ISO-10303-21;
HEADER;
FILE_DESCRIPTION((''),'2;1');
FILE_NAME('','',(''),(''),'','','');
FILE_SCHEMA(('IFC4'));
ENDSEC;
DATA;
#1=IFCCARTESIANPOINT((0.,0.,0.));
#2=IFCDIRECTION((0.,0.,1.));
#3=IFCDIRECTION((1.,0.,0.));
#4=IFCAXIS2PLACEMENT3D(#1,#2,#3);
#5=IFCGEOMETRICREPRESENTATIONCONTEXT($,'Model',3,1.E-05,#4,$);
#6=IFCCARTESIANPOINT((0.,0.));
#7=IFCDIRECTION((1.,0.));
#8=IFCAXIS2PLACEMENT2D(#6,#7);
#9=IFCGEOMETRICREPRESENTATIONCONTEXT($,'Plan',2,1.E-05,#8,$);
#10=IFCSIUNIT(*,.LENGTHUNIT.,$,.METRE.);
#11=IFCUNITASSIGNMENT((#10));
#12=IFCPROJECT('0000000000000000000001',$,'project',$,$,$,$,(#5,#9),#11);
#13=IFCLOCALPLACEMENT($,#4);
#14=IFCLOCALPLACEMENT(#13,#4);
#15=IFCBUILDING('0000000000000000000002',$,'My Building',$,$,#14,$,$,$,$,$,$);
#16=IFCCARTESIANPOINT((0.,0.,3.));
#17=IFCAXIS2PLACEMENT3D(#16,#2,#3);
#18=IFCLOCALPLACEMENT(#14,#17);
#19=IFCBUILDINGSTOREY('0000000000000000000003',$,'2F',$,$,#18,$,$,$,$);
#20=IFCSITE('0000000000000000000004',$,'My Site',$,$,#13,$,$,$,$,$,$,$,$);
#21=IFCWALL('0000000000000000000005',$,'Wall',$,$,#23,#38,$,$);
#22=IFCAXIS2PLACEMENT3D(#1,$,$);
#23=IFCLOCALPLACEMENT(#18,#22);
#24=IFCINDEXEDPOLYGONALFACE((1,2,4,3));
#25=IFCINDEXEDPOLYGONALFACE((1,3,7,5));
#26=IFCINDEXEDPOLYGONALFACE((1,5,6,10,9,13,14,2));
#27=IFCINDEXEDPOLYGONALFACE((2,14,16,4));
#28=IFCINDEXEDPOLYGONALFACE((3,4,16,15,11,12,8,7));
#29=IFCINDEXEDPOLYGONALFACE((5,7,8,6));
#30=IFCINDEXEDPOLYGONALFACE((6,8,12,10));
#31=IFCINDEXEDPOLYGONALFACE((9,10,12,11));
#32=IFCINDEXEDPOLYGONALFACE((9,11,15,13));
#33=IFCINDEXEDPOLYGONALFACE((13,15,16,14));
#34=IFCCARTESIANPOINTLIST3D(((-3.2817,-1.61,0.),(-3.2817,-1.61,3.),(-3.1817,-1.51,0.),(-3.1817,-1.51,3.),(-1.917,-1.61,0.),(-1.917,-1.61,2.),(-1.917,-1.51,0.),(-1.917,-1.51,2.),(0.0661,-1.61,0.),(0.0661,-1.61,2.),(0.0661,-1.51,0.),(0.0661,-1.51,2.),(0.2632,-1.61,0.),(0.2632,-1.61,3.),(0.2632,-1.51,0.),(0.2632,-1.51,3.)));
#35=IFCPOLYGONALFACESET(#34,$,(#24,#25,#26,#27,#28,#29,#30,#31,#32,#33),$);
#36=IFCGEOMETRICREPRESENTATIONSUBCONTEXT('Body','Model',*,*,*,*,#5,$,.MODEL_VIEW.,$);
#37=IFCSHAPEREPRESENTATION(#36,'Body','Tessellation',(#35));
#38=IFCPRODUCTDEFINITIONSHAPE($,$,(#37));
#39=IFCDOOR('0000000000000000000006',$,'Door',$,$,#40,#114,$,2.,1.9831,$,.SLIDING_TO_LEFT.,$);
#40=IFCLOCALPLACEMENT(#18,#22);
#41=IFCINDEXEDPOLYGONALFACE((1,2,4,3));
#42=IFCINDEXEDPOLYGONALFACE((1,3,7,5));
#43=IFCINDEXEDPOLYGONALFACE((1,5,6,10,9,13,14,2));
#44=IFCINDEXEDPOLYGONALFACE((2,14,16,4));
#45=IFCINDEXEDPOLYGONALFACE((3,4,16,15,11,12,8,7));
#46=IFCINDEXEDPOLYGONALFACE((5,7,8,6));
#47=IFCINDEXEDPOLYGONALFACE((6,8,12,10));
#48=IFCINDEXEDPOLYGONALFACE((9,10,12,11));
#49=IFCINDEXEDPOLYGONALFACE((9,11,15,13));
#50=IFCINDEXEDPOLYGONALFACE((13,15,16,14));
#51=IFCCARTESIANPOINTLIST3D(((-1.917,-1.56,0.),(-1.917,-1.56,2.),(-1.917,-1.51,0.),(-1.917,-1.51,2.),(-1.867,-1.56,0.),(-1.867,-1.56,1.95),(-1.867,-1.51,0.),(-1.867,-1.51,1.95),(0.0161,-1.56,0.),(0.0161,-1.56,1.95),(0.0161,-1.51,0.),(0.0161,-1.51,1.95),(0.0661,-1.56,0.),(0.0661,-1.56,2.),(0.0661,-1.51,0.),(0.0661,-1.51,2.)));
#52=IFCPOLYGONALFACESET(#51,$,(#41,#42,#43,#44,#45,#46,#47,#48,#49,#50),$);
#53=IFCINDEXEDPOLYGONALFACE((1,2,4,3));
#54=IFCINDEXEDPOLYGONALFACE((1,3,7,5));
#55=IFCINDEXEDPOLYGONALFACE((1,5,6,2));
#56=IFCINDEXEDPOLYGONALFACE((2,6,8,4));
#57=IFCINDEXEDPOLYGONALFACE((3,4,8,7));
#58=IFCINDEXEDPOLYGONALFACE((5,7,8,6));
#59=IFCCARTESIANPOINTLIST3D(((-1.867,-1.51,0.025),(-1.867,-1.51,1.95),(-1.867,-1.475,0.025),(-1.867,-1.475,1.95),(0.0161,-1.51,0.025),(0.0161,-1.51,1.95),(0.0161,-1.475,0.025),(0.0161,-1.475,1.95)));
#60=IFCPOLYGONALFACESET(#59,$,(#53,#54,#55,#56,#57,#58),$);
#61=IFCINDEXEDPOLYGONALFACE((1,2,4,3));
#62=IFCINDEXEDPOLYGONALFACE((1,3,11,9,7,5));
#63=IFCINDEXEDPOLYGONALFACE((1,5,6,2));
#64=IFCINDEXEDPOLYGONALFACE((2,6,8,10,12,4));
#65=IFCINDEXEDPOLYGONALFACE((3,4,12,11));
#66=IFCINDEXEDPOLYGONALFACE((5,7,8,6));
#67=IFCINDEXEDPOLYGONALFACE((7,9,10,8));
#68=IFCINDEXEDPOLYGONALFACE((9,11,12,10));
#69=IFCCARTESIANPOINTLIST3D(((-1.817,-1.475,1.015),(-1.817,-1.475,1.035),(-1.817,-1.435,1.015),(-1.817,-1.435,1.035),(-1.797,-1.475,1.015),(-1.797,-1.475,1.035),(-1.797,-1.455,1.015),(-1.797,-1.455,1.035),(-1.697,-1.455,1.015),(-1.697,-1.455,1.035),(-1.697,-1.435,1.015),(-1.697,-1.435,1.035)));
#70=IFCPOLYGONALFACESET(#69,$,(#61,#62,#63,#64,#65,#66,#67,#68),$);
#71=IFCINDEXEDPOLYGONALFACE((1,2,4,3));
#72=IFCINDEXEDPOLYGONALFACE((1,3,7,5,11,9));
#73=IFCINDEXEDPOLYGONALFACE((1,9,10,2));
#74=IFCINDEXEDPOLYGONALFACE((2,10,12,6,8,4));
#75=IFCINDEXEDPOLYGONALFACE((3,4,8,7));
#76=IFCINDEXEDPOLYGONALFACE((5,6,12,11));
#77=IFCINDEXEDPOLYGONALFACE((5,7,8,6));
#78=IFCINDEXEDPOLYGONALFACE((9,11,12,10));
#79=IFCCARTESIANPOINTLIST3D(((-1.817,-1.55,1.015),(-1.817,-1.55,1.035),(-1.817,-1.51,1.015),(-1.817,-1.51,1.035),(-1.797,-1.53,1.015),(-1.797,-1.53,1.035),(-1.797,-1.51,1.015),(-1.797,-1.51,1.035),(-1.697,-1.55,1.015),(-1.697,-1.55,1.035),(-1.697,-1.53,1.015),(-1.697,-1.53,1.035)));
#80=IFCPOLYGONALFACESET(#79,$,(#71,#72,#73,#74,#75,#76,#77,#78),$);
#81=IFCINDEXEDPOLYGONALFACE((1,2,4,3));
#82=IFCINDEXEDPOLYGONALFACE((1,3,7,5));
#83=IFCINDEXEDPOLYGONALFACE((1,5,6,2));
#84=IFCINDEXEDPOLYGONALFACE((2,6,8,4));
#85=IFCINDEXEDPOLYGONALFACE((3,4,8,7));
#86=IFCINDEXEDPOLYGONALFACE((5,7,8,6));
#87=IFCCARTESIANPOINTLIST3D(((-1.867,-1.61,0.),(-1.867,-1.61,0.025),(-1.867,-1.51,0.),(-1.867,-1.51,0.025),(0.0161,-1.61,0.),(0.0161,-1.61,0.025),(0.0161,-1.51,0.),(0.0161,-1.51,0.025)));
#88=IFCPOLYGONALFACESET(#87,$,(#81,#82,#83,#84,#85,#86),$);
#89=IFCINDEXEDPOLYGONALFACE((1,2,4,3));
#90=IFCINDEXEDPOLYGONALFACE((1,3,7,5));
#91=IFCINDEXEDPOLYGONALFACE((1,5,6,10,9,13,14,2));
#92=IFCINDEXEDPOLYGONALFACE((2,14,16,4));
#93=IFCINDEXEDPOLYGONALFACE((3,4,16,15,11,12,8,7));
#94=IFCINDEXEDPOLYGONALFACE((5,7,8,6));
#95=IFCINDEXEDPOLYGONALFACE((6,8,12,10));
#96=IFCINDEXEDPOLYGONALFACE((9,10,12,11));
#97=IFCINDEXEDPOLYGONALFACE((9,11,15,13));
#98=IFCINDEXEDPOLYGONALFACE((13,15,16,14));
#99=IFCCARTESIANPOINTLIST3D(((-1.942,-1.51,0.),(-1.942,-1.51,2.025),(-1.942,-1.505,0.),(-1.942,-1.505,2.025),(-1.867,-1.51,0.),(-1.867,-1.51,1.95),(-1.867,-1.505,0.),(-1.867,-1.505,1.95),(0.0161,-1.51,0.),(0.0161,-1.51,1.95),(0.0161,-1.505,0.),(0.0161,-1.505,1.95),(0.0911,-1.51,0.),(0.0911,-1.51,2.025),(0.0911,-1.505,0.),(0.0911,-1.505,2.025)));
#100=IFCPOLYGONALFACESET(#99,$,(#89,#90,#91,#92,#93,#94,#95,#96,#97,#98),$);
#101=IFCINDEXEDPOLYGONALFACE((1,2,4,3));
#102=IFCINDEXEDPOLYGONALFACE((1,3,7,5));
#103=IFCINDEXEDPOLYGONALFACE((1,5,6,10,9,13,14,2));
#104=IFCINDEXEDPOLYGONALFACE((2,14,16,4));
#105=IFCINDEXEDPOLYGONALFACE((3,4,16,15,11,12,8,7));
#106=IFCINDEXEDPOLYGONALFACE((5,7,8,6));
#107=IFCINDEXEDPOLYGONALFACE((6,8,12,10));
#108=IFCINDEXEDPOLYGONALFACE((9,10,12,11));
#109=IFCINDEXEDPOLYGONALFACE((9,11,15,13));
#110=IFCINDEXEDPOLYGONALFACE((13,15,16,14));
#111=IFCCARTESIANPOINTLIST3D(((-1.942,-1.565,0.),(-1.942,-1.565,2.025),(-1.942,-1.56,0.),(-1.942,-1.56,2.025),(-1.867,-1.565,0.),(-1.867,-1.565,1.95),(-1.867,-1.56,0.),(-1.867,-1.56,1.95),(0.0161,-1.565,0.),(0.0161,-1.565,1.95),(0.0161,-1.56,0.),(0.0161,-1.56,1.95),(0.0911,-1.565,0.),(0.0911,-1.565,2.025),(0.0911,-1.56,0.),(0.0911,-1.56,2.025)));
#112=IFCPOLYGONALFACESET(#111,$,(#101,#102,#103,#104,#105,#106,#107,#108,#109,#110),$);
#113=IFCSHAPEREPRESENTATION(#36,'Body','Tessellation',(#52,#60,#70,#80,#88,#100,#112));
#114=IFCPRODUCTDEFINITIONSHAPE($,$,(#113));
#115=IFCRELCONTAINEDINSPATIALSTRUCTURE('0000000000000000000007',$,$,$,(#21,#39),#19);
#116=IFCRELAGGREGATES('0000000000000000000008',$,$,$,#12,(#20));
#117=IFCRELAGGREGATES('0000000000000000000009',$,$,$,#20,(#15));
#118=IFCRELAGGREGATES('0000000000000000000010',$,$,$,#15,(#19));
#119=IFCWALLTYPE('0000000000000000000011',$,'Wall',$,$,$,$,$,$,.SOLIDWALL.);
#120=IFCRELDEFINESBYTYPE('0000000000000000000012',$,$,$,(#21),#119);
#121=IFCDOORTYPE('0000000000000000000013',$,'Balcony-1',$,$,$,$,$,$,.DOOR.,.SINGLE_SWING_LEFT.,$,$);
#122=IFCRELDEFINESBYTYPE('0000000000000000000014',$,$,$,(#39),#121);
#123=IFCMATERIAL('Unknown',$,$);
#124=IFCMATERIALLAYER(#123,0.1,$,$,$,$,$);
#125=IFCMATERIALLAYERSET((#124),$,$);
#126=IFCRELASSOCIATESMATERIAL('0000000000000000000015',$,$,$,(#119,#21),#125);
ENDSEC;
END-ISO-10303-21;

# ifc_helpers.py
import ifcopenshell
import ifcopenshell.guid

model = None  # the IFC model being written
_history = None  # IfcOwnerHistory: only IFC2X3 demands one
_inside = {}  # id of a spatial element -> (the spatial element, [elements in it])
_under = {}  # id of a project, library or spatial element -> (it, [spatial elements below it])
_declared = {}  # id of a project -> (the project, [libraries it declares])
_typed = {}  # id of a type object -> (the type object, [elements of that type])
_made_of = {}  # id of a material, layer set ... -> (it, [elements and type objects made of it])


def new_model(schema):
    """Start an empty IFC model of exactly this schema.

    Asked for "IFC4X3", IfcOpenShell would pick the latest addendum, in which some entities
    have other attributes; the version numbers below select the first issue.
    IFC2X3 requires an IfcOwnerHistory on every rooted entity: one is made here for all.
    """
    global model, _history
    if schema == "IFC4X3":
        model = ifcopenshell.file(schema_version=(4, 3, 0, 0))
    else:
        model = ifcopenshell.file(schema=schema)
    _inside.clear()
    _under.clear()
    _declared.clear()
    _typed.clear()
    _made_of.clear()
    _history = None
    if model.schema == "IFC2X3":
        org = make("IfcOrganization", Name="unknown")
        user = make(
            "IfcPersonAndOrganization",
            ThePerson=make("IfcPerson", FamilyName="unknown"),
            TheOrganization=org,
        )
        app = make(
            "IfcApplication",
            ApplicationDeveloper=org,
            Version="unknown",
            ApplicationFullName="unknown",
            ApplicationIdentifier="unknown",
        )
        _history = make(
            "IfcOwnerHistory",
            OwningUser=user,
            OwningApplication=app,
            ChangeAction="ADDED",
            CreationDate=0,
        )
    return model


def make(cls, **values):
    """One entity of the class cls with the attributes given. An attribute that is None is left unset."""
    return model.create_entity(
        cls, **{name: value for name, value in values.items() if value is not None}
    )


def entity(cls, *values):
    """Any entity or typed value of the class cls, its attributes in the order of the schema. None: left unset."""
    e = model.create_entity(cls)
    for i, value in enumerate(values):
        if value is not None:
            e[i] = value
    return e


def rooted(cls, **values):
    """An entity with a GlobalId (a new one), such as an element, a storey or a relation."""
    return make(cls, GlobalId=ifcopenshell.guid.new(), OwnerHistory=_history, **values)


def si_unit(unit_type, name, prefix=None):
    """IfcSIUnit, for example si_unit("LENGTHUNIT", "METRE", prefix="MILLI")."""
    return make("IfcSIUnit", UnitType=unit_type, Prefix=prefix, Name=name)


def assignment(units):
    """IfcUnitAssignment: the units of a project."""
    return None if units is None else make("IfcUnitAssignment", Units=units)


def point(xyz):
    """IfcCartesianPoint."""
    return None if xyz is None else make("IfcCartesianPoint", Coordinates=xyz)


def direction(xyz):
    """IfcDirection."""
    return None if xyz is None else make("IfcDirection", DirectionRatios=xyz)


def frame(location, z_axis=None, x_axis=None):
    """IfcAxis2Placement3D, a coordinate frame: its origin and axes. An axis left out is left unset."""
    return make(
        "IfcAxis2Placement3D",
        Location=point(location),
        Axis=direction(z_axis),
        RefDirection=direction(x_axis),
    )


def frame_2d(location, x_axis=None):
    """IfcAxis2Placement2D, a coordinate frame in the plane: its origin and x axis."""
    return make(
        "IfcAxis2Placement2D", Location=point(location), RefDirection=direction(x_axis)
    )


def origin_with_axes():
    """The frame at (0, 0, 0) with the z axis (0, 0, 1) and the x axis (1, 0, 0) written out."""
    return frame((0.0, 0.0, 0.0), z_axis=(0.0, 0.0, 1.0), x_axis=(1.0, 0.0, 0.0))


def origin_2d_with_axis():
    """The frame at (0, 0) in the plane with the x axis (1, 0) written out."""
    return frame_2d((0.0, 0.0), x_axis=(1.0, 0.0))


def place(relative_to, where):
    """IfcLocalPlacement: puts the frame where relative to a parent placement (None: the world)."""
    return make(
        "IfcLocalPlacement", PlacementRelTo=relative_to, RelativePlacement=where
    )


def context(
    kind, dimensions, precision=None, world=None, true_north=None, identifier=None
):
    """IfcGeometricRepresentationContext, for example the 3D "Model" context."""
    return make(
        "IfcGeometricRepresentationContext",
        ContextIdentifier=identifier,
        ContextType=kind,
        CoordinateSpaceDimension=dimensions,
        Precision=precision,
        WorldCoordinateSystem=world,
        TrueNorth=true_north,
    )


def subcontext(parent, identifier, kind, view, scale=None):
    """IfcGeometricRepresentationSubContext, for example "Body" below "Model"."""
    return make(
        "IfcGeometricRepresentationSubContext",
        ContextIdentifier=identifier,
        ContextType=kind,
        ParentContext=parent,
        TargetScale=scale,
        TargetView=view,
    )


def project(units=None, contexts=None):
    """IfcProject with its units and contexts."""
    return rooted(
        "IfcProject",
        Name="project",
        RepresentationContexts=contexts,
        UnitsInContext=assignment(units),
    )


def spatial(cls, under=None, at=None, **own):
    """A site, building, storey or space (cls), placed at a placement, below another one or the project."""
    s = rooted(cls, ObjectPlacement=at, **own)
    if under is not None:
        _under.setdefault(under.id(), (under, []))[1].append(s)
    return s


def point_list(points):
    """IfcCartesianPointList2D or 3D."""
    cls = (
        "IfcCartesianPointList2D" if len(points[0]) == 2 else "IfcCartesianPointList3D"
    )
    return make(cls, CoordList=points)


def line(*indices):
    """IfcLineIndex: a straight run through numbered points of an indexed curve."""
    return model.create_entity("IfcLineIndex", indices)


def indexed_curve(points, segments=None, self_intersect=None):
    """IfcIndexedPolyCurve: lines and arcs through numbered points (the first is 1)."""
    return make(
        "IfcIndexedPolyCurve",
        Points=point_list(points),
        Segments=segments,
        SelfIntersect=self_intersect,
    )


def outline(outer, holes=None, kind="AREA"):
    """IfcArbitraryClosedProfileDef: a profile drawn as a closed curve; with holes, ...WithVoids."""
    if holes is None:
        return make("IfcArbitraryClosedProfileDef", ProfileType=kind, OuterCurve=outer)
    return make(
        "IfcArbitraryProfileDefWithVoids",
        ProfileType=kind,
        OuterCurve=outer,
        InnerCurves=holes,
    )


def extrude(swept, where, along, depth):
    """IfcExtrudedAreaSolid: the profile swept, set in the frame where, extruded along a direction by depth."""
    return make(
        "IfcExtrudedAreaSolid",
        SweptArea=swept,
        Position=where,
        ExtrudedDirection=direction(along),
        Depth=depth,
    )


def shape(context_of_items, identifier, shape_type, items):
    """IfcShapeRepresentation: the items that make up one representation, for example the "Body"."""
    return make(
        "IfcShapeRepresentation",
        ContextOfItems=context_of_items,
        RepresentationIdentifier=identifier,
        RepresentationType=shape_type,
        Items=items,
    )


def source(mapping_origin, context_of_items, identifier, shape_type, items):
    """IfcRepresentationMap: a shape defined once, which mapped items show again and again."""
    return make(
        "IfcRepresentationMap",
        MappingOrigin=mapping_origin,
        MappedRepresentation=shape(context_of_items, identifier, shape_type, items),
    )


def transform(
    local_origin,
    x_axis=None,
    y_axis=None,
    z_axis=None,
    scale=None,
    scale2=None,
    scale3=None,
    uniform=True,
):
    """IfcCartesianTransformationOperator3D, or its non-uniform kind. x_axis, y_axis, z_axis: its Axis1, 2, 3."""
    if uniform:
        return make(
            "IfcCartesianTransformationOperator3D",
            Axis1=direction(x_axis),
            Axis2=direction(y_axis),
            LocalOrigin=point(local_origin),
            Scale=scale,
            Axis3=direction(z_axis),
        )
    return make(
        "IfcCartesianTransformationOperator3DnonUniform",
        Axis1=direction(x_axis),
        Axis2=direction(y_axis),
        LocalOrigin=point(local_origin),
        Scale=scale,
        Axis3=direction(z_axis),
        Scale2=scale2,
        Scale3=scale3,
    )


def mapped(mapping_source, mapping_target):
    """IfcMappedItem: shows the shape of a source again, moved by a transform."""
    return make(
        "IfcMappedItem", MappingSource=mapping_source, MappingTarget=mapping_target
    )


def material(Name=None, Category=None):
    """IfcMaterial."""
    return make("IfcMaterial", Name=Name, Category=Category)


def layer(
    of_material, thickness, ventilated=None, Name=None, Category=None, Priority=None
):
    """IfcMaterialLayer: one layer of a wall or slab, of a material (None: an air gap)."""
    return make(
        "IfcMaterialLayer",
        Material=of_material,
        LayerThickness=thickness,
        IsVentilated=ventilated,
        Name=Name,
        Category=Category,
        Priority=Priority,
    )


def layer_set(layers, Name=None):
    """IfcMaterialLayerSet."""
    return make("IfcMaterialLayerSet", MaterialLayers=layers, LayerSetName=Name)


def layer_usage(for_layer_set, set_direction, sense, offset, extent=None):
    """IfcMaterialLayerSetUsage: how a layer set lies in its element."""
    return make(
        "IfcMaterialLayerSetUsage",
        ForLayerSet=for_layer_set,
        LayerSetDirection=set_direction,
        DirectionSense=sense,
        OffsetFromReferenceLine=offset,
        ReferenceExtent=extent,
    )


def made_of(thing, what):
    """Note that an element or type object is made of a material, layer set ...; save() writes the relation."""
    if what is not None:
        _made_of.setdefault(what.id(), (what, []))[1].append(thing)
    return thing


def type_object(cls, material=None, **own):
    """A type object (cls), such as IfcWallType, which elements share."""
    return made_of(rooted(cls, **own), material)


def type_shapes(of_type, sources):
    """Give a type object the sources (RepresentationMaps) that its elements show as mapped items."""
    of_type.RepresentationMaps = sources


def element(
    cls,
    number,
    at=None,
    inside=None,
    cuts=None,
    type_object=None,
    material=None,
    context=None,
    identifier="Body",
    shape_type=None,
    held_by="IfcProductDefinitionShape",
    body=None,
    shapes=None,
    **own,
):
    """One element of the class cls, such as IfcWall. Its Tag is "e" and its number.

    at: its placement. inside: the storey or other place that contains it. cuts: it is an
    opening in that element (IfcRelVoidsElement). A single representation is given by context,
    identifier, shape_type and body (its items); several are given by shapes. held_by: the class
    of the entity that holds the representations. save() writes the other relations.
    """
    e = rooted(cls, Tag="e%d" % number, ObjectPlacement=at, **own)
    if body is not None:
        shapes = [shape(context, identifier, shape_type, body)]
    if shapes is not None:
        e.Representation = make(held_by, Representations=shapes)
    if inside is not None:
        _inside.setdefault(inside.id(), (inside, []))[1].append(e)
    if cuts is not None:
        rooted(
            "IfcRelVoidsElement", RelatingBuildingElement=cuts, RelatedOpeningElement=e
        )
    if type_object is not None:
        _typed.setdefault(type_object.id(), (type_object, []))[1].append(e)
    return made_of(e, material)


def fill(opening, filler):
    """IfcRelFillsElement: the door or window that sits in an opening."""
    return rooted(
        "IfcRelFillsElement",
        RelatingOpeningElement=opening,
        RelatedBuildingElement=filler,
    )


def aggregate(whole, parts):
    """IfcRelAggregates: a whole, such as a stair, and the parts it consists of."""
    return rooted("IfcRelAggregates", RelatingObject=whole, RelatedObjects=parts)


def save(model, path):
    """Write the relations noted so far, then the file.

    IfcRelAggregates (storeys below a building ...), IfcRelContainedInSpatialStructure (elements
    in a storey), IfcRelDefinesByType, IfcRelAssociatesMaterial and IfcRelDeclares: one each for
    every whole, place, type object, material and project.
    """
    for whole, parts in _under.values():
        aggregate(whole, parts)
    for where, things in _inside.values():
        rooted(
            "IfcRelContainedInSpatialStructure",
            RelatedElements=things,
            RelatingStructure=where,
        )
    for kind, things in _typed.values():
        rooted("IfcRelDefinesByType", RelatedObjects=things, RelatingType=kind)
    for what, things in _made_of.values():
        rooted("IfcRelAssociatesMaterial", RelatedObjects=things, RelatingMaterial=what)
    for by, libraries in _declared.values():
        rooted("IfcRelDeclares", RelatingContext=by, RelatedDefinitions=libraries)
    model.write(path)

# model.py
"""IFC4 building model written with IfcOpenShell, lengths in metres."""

from ifc_helpers import new_model, entity, si_unit, frame, origin_with_axes, origin_2d_with_axis, place, context, subcontext, project, spatial, line, indexed_curve, outline, extrude, shape, source, transform, mapped, material, layer, layer_set, layer_usage, type_object, type_shapes, element, fill, save


model = new_model("IFC4")

# Units and contexts
model_context_1 = context("Model", 3, precision=1e-05, world=origin_with_axes())
plan_context = context("Plan", 2, precision=1e-05, world=origin_2d_with_axis())
body_context_1 = subcontext(model_context_1, "Body", "Model", "MODEL_VIEW")
body_context_2 = subcontext(plan_context, "Body", "Plan", "PLAN_VIEW")
ifc_project = project(units=[si_unit("LENGTHUNIT", "METRE")], contexts=[model_context_1, plan_context])

# Site, building, storey
site_placement = place(None, origin_with_axes())
site = spatial("IfcSite", under=ifc_project, at=site_placement, Name="My Site")
building_placement = place(site_placement, origin_with_axes())
building = spatial("IfcBuilding", under=site, at=building_placement, Name="My Building")
storey_placement = place(building_placement, frame((0.0, 0.0, 3.0), z_axis=(0.0, 0.0, 1.0), x_axis=(1.0, 0.0, 0.0)))
storey = spatial("IfcBuildingStorey", under=building, at=storey_placement, Name="2F")

# Shared definitions
ifc_material = material(Name="Unknown")

# Shared definitions
ifc_layer_1 = layer(ifc_material, 0.1)
ifc_layer_set_1 = layer_set([ifc_layer_1])
wall_type = type_object("IfcWallType", Name="Wall", PredefinedType="SOLIDWALL", material=ifc_layer_set_1)

# Wall, opening, door
ifc_layer_usage_1 = layer_usage(ifc_layer_set_1, "AXIS2", "POSITIVE", 0.0)
wall_1_placement = place(storey_placement, frame((-3.2817, -1.61, 0.0), z_axis=(0.0, 0.0, 1.0), x_axis=(1.0, 0.0, 0.0)))
wall_1 = element("IfcWall", 1, at=wall_1_placement, inside=storey, type_object=wall_type, material=ifc_layer_usage_1, Name="Wall", context=body_context_1, shape_type="SweptSolid", body=[
    extrude(outline(indexed_curve([(0.0, 0.0), (0.1, 0.1), (3.5448, 0.1), (3.5448, 0.0)], segments=[line(1, 2, 3, 4, 1)])), origin_with_axes(), (0.0, 0.0, 1.0), 3.0),
])
shared_shape_1 = source(origin_with_axes(), body_context_1, "Body", "SweptSolid", [
    extrude(outline(indexed_curve([(0.0, 0.0), (1.9831, 0.0), (1.9831, 2.0), (0.0, 2.0)], segments=[line(1, 2, 3, 4, 1)])), frame((0.0, -0.6, 0.0), z_axis=(0.0, -1.0, 0.0), x_axis=(1.0, 0.0, 0.0)), (0.0, 0.0, -1.0), 1.2),
])
opening_1_placement = place(wall_1_placement, frame((3.3477, 0.1, 0.0), z_axis=(0.0, 0.0, 1.0), x_axis=(-1.0, 0.0, 0.0)))
opening_1 = element("IfcOpeningElement", 2, at=opening_1_placement, cuts=wall_1, PredefinedType="OPENING", context=body_context_1, shape_type="MappedRepresentation", body=[
    mapped(shared_shape_1, transform((0.0, 0.0, 0.0), x_axis=(1.0, 0.0, 0.0), y_axis=(0.0, 1.0, 0.0), z_axis=(0.0, 0.0, 1.0), scale=1.0)),
])
door_type_1 = type_object("IfcDoorType", Name="Balcony-1", OperationType="SINGLE_SWING_LEFT", PredefinedType="DOOR")
shared_shape_2 = source(origin_with_axes(), body_context_1, "Body", "SweptSolid", [
    extrude(outline(indexed_curve([(0.0, 0.0), (0.0, 2.0), (1.9831, 2.0), (1.9831, 0.0), (1.9331, 0.0), (1.9331, 1.95), (0.05, 1.95), (0.05, 0.0)], segments=[line(1, 2, 3, 4, 5, 6, 7, 8, 1)])), frame((0.0, 0.0, 0.0), z_axis=(0.0, -1.0, 0.0), x_axis=(1.0, 0.0, 0.0)), (0.0, 0.0, -1.0), 0.05),
    extrude(outline(indexed_curve([(0.0, 0.0), (1.8831, 0.0), (1.8831, 0.035), (0.0, 0.035)], segments=[line(1, 2, 3, 4, 1)])), frame((0.05, -0.035, 0.025), z_axis=(0.0, 0.0, 1.0), x_axis=(1.0, 0.0, 0.0)), (0.0, 0.0, 1.0), 1.925),
    extrude(outline(indexed_curve([(0.0, 0.0), (0.0, -0.04), (-0.12, -0.04), (-0.12, -0.02), (-0.02, -0.02), (-0.02, 0.0)], segments=[line(1, 2, 3, 4, 5, 6, 1)])), frame((1.8831, -0.035, 1.015), z_axis=(0.0, 0.0, 1.0), x_axis=(1.0, 0.0, 0.0)), (0.0, 0.0, 1.0), 0.02),
    extrude(outline(indexed_curve([(0.0, 0.0), (0.0, 0.04), (-0.12, 0.04), (-0.12, 0.02), (-0.02, 0.02), (-0.02, 0.0)], segments=[line(1, 2, 3, 4, 5, 6, 1)])), frame((1.8831, 0.0, 1.015), z_axis=(0.0, 0.0, 1.0), x_axis=(1.0, 0.0, 0.0)), (0.0, 0.0, 1.0), 0.02),
    extrude(outline(indexed_curve([(0.0, 0.0), (1.8831, 0.0), (1.8831, 0.1), (0.0, 0.1)], segments=[line(1, 2, 3, 4, 1)])), frame((0.05, 0.0, 0.0), z_axis=(0.0, 0.0, 1.0), x_axis=(1.0, 0.0, 0.0)), (0.0, 0.0, 1.0), 0.025),
    extrude(outline(indexed_curve([(0.0, 0.0), (0.0, 2.025), (2.0331, 2.025), (2.0331, 0.0), (1.9581, 0.0), (1.9581, 1.95), (0.075, 1.95), (0.075, 0.0)], segments=[line(1, 2, 3, 4, 5, 6, 7, 8, 1)])), frame((-0.025, -0.005, 0.0), z_axis=(0.0, -1.0, 0.0), x_axis=(1.0, 0.0, 0.0)), (0.0, 0.0, -1.0), 0.005),
    extrude(outline(indexed_curve([(0.0, 0.0), (0.0, 2.025), (2.0331, 2.025), (2.0331, 0.0), (1.9581, 0.0), (1.9581, 1.95), (0.075, 1.95), (0.075, 0.0)], segments=[line(1, 2, 3, 4, 5, 6, 7, 8, 1)])), frame((-0.025, 0.05, 0.0), z_axis=(0.0, -1.0, 0.0), x_axis=(1.0, 0.0, 0.0)), (0.0, 0.0, -1.0), 0.005),
])
shared_shape_3 = source(origin_with_axes(), body_context_2, "Body", "Curve2D", [
    entity("IfcIndexedPolyCurve", entity("IfcCartesianPointList2D", [[0.0, 0.0], [0.05, 0.0], [0.05, 0.05], [0.0, 0.05]]), [entity("IfcLineIndex", [1, 2, 3, 4, 1])]),
    entity("IfcIndexedPolyCurve", entity("IfcCartesianPointList2D", [[1.9831, 0.0], [1.9331, 0.0], [1.9331, 0.05], [1.9831, 0.05]]), [entity("IfcLineIndex", [1, 2, 3, 4, 1])]),
    entity("IfcIndexedPolyCurve", entity("IfcCartesianPointList2D", [[-0.8915, -0.035], [0.9915, -0.035], [0.9915, 0.0], [-0.8915, 0.0]]), [entity("IfcLineIndex", [1, 2, 3, 4, 1])]),
])
type_shapes(door_type_1, [shared_shape_2, shared_shape_3])
door_1_placement = place(opening_1_placement, frame((0.0, 0.0, 0.0), z_axis=(0.0, 0.0, 1.0), x_axis=(1.0, 0.0, 0.0)))
door_1 = element("IfcDoor", 3, at=door_1_placement, inside=storey, type_object=door_type_1, Name="Door", OperationType="SLIDING_TO_LEFT", OverallHeight=2.0, OverallWidth=1.9831, shapes=[
    shape(body_context_1, "Body", "MappedRepresentation", [mapped(shared_shape_2, transform((0.0, 0.0, 0.0), x_axis=(1.0, 0.0, 0.0), y_axis=(0.0, 1.0, 0.0), z_axis=(0.0, 0.0, 1.0), scale=1.0))]),
    shape(body_context_2, "Body", "MappedRepresentation", [mapped(shared_shape_3, transform((0.0, 0.0, 0.0), x_axis=(1.0, 0.0, 0.0), y_axis=(0.0, 1.0, 0.0), z_axis=(0.0, 0.0, 1.0), scale=1.0))]),
])
fill(opening_1, door_1)

save(model, "model.ifc")
